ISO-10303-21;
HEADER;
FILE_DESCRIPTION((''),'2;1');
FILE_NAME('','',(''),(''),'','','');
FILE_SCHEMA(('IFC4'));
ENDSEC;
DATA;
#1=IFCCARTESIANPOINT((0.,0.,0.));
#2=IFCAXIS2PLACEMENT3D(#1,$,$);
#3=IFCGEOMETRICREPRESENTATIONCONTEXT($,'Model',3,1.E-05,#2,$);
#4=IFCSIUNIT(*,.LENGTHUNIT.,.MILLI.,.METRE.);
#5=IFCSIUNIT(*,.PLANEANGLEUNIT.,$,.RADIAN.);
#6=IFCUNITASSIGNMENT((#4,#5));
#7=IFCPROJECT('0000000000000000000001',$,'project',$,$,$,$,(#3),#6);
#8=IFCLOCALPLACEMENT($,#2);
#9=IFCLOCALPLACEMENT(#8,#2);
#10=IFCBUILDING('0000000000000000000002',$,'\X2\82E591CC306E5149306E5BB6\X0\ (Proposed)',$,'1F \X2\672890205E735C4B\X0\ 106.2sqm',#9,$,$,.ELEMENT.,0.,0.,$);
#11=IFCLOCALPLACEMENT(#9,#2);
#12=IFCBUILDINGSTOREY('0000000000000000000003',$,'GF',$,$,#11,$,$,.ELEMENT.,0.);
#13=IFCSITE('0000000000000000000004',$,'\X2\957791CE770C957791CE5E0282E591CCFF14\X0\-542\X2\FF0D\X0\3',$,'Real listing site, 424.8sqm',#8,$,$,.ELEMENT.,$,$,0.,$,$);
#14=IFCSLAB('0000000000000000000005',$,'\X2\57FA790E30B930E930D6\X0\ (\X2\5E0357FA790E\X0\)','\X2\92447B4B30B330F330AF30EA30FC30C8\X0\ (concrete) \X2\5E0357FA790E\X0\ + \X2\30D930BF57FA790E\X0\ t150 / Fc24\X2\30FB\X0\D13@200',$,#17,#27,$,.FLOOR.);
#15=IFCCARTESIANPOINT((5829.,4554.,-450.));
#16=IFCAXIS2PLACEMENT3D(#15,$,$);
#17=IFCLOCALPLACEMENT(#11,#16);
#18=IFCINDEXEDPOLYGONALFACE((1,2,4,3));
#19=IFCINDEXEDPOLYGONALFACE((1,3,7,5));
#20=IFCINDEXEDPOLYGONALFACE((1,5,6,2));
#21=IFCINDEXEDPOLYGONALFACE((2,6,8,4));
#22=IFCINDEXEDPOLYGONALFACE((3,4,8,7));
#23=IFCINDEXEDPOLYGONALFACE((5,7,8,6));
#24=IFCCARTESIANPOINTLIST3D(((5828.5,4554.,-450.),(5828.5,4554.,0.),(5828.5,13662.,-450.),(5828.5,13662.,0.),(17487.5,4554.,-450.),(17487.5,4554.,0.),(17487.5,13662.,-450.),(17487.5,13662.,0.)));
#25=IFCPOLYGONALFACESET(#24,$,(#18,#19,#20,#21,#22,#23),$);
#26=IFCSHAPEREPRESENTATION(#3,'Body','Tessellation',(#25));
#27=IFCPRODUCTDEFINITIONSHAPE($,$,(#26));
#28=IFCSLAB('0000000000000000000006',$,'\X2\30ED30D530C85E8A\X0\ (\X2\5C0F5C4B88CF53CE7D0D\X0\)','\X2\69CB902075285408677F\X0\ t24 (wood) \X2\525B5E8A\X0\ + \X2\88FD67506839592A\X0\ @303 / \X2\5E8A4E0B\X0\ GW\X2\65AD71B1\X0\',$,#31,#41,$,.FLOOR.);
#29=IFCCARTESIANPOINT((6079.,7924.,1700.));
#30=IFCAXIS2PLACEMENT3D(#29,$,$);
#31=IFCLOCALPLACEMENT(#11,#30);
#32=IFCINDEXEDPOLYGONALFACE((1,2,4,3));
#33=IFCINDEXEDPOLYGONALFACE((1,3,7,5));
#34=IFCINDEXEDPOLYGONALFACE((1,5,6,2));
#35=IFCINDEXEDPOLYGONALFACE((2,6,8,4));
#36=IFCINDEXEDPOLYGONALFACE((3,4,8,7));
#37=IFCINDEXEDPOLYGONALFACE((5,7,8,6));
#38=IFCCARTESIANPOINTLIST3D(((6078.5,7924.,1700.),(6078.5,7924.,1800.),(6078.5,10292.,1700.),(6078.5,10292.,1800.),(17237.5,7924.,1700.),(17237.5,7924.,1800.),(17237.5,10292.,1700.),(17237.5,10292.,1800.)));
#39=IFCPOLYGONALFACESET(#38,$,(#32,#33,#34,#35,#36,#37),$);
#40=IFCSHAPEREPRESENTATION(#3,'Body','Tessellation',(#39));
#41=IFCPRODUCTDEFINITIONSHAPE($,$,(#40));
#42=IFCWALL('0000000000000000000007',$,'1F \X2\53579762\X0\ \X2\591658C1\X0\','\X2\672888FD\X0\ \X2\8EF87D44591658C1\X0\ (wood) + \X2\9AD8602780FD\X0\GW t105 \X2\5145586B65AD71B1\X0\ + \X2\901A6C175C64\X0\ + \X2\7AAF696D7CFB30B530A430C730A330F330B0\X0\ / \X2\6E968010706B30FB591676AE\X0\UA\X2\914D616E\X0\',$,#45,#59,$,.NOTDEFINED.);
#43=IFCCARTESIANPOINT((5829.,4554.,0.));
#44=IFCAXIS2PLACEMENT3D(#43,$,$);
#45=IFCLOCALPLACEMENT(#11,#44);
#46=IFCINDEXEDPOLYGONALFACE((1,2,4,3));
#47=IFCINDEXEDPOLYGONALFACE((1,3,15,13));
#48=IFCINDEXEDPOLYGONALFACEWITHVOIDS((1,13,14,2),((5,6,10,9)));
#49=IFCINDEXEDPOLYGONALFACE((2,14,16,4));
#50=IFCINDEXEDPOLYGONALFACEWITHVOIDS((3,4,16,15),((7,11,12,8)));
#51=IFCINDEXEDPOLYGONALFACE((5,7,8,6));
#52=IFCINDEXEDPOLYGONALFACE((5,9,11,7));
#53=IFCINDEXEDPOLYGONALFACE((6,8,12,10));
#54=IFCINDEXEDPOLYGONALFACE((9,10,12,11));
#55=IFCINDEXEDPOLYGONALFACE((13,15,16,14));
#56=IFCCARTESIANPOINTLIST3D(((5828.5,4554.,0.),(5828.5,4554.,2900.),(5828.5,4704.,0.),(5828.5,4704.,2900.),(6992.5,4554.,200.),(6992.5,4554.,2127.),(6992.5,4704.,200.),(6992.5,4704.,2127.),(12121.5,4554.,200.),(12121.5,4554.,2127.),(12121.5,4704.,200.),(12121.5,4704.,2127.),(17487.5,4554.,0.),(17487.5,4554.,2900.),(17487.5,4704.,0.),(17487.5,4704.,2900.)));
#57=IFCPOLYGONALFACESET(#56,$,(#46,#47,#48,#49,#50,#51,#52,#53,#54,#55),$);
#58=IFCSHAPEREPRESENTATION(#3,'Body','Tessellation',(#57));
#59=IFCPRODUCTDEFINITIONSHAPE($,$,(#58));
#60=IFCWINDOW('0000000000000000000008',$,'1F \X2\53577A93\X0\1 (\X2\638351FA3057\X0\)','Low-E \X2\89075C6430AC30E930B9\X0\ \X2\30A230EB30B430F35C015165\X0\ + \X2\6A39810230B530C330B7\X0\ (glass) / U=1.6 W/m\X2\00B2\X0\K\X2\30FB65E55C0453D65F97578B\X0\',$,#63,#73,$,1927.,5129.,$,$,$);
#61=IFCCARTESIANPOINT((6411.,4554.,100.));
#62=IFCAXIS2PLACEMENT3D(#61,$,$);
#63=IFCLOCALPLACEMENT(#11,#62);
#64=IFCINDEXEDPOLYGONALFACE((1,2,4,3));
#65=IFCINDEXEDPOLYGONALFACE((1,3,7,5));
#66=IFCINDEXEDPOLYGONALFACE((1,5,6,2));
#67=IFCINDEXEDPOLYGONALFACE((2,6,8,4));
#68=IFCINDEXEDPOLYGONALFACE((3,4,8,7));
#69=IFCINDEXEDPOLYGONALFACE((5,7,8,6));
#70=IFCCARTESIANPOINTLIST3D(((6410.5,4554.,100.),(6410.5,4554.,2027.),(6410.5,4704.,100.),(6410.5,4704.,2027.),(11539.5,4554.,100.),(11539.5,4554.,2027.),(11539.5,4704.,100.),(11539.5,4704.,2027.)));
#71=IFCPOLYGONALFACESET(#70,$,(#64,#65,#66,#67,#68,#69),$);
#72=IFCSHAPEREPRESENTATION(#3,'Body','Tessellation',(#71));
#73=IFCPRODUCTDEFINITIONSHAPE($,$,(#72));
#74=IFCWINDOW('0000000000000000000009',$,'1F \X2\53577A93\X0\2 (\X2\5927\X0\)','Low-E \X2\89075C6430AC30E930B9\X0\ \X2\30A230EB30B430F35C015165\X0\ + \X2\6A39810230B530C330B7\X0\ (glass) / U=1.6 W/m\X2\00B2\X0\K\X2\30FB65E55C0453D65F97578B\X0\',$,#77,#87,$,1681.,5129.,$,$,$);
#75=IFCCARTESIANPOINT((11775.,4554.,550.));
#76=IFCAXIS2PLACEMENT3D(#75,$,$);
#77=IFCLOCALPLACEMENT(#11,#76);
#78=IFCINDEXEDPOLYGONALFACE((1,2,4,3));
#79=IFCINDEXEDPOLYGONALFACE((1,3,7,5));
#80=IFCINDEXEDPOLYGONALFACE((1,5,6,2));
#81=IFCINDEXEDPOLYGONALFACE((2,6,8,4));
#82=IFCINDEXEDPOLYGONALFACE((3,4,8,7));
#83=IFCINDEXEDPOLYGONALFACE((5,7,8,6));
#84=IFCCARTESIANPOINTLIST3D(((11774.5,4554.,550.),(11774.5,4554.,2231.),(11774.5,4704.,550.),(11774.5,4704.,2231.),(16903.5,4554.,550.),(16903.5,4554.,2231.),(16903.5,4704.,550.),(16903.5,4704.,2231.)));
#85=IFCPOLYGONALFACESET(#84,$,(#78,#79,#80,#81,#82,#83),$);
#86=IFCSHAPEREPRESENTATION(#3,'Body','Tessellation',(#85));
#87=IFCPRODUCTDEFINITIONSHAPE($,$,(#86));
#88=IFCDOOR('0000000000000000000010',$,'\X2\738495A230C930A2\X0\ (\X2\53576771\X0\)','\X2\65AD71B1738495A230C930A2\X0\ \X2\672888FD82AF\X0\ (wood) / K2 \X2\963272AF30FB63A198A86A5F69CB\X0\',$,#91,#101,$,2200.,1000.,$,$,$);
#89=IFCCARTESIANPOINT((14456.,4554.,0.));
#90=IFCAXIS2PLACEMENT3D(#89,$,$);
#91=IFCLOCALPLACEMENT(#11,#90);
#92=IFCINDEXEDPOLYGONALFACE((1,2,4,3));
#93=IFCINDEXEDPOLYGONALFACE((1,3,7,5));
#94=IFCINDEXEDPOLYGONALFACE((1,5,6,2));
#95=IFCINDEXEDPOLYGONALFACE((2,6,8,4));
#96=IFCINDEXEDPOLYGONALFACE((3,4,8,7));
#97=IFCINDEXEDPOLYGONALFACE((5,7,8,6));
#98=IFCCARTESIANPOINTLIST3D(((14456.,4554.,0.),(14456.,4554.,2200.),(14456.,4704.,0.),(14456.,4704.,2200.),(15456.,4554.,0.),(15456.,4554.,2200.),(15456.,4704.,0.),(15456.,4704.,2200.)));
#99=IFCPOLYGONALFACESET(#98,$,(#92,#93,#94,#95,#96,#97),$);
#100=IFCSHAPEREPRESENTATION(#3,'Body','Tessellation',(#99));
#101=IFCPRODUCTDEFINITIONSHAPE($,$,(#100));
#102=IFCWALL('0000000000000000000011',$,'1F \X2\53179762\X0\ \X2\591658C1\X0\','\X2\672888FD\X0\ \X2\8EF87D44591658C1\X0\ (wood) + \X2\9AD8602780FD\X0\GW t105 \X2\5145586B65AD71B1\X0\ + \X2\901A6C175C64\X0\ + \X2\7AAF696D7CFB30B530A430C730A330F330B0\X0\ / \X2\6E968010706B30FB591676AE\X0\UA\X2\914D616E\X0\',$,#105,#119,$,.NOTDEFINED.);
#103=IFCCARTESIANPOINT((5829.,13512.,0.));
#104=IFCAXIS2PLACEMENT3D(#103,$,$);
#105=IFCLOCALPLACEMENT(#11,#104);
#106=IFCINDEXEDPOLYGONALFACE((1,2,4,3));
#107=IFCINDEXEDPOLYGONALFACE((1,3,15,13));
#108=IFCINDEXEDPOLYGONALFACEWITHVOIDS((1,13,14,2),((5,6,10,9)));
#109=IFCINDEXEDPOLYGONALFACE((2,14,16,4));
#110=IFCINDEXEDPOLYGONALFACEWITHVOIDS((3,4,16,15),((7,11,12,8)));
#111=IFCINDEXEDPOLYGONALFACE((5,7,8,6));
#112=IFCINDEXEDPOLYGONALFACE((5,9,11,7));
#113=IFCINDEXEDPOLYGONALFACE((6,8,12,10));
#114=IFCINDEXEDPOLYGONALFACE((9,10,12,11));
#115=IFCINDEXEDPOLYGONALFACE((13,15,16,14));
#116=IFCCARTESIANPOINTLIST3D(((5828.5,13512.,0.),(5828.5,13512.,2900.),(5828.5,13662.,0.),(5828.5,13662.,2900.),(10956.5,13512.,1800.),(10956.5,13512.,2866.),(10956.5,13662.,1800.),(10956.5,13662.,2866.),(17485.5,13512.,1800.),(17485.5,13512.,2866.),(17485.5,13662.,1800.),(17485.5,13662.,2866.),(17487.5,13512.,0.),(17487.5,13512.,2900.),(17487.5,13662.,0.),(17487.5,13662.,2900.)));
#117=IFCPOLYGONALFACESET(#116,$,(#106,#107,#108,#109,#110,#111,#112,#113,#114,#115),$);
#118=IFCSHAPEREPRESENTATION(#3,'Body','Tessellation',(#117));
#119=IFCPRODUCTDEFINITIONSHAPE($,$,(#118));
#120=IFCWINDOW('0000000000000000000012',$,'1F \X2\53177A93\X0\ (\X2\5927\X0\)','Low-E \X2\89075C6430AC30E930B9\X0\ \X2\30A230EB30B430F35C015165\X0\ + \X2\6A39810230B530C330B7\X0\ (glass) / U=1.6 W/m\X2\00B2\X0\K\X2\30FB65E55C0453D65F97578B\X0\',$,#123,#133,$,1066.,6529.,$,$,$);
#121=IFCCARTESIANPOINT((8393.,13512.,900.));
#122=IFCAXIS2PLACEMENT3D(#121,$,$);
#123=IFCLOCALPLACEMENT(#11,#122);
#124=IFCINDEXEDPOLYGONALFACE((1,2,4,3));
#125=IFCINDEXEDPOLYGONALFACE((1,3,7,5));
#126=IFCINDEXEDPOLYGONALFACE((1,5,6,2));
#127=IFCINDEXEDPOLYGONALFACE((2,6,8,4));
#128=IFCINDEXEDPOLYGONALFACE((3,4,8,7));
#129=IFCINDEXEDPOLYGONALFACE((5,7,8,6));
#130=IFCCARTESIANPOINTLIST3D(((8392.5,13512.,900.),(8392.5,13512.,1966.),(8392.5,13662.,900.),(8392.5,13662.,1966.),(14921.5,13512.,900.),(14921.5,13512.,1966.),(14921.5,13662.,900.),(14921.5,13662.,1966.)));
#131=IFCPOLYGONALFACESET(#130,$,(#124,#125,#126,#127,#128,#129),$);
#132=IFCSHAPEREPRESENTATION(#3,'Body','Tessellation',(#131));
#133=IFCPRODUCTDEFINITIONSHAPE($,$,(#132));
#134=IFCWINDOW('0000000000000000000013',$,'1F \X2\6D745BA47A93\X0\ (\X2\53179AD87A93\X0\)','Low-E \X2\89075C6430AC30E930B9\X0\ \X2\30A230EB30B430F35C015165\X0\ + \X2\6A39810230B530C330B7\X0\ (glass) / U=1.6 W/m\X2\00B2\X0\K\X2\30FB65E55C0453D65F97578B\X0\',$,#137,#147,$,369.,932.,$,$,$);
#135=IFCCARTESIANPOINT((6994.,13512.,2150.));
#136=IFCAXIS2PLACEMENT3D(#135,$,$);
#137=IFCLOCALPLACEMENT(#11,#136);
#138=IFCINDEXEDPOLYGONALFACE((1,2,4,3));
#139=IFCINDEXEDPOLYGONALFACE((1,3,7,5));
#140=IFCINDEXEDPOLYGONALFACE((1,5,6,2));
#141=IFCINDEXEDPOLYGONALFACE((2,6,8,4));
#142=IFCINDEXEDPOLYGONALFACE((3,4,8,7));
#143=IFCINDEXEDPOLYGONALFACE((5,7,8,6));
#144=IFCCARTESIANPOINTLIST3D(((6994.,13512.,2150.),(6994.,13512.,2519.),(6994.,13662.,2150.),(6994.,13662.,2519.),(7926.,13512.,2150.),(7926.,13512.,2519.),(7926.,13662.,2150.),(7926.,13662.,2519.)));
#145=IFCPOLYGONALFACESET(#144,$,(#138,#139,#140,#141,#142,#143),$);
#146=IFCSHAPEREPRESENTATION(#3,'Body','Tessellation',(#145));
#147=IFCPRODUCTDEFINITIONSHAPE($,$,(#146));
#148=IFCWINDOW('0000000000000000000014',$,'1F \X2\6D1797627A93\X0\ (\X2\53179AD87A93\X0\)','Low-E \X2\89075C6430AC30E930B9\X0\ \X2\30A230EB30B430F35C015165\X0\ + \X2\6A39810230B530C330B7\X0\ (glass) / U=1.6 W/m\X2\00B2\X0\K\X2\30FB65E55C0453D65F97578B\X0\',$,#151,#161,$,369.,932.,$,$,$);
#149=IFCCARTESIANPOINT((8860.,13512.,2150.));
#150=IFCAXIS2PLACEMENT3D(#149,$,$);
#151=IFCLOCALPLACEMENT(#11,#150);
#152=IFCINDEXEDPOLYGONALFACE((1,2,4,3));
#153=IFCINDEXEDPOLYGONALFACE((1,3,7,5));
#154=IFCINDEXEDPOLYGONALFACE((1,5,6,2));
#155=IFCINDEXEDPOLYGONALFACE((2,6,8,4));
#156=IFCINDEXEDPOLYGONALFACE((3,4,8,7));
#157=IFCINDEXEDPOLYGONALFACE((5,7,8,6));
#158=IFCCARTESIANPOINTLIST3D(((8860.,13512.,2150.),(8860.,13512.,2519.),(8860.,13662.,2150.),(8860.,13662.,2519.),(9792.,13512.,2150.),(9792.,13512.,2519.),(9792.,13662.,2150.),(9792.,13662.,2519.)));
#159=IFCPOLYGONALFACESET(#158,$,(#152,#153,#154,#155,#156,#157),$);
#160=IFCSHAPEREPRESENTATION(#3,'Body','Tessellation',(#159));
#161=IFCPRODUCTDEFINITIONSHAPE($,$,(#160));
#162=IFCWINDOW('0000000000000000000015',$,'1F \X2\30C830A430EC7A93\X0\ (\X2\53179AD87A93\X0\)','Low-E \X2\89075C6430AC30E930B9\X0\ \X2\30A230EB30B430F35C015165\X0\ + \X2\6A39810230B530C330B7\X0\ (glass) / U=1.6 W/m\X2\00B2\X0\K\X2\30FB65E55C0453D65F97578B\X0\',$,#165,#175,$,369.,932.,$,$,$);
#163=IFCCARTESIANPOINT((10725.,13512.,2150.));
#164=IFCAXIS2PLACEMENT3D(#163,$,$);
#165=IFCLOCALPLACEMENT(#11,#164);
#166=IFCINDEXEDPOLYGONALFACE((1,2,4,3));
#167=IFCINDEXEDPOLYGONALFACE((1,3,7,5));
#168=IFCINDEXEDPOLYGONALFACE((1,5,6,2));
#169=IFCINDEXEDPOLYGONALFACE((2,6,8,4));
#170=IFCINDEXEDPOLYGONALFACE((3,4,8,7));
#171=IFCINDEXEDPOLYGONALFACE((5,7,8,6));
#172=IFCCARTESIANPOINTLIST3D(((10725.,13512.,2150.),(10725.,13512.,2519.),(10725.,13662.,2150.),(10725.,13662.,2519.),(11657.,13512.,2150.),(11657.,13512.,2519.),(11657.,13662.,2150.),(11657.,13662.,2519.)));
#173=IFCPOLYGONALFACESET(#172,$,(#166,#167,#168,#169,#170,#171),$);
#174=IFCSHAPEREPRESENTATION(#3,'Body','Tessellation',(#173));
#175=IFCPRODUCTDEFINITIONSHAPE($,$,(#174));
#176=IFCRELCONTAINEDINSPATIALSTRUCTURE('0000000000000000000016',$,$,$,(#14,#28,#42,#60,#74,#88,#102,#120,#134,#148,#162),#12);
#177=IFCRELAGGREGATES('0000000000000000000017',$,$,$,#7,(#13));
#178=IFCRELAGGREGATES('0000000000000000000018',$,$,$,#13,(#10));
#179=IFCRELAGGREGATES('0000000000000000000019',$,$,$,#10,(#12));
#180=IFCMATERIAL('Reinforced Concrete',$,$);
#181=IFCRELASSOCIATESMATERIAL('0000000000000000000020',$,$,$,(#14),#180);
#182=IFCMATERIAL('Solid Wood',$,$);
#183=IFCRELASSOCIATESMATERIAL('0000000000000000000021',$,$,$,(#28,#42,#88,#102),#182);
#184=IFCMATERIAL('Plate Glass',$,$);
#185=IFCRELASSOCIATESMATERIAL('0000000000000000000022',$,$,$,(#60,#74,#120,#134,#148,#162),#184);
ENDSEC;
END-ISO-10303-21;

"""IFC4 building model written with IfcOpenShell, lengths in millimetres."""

from ifc_helpers import new_model, si_unit, frame, frame_2d, origin, place, context, project, spatial, rectangle, extrude, material, element, fill, save


model = new_model("IFC4")

# Units and contexts
model_context = context("Model", 3, precision=1e-05, world=origin())
ifc_project = project(units=[si_unit("LENGTHUNIT", "METRE", prefix="MILLI"), si_unit("PLANEANGLEUNIT", "RADIAN")], contexts=[model_context])

# Site, building, storey
site_placement = place(None, origin())
site = spatial("IfcSite", under=ifc_project, at=site_placement, Name="長野県長野市若里４-542－3", ObjectType="Real listing site, 424.8sqm", CompositionType="ELEMENT", RefElevation=0.0)
building_placement = place(site_placement, origin())
building = spatial("IfcBuilding", under=site, at=building_placement, Name="若里の光の家 (Proposed)", ObjectType="1F 木造平屋 106.2sqm", CompositionType="ELEMENT", ElevationOfRefHeight=0.0, ElevationOfTerrain=0.0)
storey_placement = place(building_placement, origin())
storey = spatial("IfcBuildingStorey", under=building, at=storey_placement, Name="GF", CompositionType="ELEMENT", Elevation=0.0)

# Slabs
ifc_material_1 = material(Name="Reinforced Concrete")
slab_1_placement = place(storey_placement, frame((5829.0, 4554.0, -450.0)))
element("IfcSlab", 1, at=slab_1_placement, inside=storey, material=ifc_material_1, Name="基礎スラブ (布基礎)", Description="鉄筋コンクリート (concrete) 布基礎 + ベタ基礎 t150 / Fc24・D13@200", PredefinedType="FLOOR", context=model_context, shape_type="SweptSolid", body=[
    extrude(rectangle(XDim=11659.0, YDim=9108.0, at=frame_2d((5829.0, 4554.0))), frame((5829.0, 4554.0, -450.0)), (0.0, 0.0, 1.0), 450.0),
])
ifc_material_2 = material(Name="Solid Wood")
slab_2_placement = place(storey_placement, frame((6079.0, 7924.0, 1700.0)))
element("IfcSlab", 2, at=slab_2_placement, inside=storey, material=ifc_material_2, Name="ロフト床 (小屋裏収納)", Description="構造用合板 t24 (wood) 剛床 + 製材根太 @303 / 床下 GW断熱", PredefinedType="FLOOR", context=model_context, shape_type="SweptSolid", body=[
    extrude(rectangle(XDim=11159.0, YDim=2368.0, at=frame_2d((5579.0, 1184.0))), frame((6079.0, 7924.0, 1700.0)), (0.0, 0.0, 1.0), 100.0),
])

# Wall, openings, windows, door
wall_1_placement = place(storey_placement, frame((5829.0, 4554.0, 0.0)))
wall_1 = element("IfcWall", 3, at=wall_1_placement, inside=storey, material=ifc_material_2, Name="1F 南面 外壁", Description="木製 軸組外壁 (wood) + 高性能GW t105 充填断熱 + 通気層 + 窯業系サイディング / 準耐火・外皮UA配慮", PredefinedType="NOTDEFINED", context=model_context, shape_type="SweptSolid", body=[
    extrude(rectangle(XDim=11659.0, YDim=150.0, at=frame_2d((5829.0, 75.0))), frame((5829.0, 4554.0, 0.0)), (0.0, 0.0, 1.0), 2900.0),
])
opening_1_placement = place(storey_placement, frame((6411.0, 4554.0, 100.0)))
opening_1 = element("IfcOpeningElement", 4, at=opening_1_placement, cuts=wall_1, PredefinedType="NOTDEFINED", context=model_context, shape_type="SweptSolid", body=[
    extrude(rectangle(XDim=5129.0, YDim=150.0, at=frame_2d((2564.0, 75.0))), frame((6411.0, 4554.0, 100.0)), (0.0, 0.0, 1.0), 1927.0),
])
opening_2_placement = place(storey_placement, frame((11775.0, 4554.0, 550.0)))
opening_2 = element("IfcOpeningElement", 5, at=opening_2_placement, cuts=wall_1, PredefinedType="NOTDEFINED", context=model_context, shape_type="SweptSolid", body=[
    extrude(rectangle(XDim=5129.0, YDim=150.0, at=frame_2d((2564.0, 75.0))), frame((11775.0, 4554.0, 550.0)), (0.0, 0.0, 1.0), 1681.0),
])
opening_3_placement = place(storey_placement, frame((14456.0, 4554.0, 0.0)))
opening_3 = element("IfcOpeningElement", 6, at=opening_3_placement, cuts=wall_1, PredefinedType="NOTDEFINED", context=model_context, shape_type="SweptSolid", body=[
    extrude(rectangle(XDim=1000.0, YDim=150.0, at=frame_2d((500.0, 75.0))), frame((14456.0, 4554.0, 0.0)), (0.0, 0.0, 1.0), 2200.0),
])
ifc_material_3 = material(Name="Plate Glass")
window_1_placement = place(storey_placement, frame((6411.0, 4554.0, 100.0)))
window_1 = element("IfcWindow", 7, at=window_1_placement, inside=storey, material=ifc_material_3, Name="1F 南窓1 (掃出し)", Description="Low-E 複層ガラス アルゴン封入 + 樹脂サッシ (glass) / U=1.6 W/m²K・日射取得型", OverallHeight=1927.0, OverallWidth=5129.0, context=model_context, shape_type="SweptSolid", body=[
    extrude(rectangle(XDim=5129.0, YDim=150.0, at=frame_2d((2564.0, 75.0))), frame((6411.0, 4554.0, 100.0)), (0.0, 0.0, 1.0), 1927.0),
])
fill(opening_1, window_1)
window_2_placement = place(storey_placement, frame((11775.0, 4554.0, 550.0)))
window_2 = element("IfcWindow", 8, at=window_2_placement, inside=storey, material=ifc_material_3, Name="1F 南窓2 (大)", Description="Low-E 複層ガラス アルゴン封入 + 樹脂サッシ (glass) / U=1.6 W/m²K・日射取得型", OverallHeight=1681.0, OverallWidth=5129.0, context=model_context, shape_type="SweptSolid", body=[
    extrude(rectangle(XDim=5129.0, YDim=150.0, at=frame_2d((2564.0, 75.0))), frame((11775.0, 4554.0, 550.0)), (0.0, 0.0, 1.0), 1681.0),
])
fill(opening_2, window_2)
door_1_placement = place(storey_placement, frame((14456.0, 4554.0, 0.0)))
door_1 = element("IfcDoor", 9, at=door_1_placement, inside=storey, material=ifc_material_2, Name="玄関ドア (南東)", Description="断熱玄関ドア 木製芯 (wood) / K2 防犯・採風機構", OverallHeight=2200.0, OverallWidth=1000.0, context=model_context, shape_type="SweptSolid", body=[
    extrude(rectangle(XDim=1000.0, YDim=150.0, at=frame_2d((500.0, 75.0))), frame((14456.0, 4554.0, 0.0)), (0.0, 0.0, 1.0), 2200.0),
])
fill(opening_3, door_1)

# Wall, openings, windows
wall_2_placement = place(storey_placement, frame((5829.0, 13512.0, 0.0)))
wall_2 = element("IfcWall", 10, at=wall_2_placement, inside=storey, material=ifc_material_2, Name="1F 北面 外壁", Description="木製 軸組外壁 (wood) + 高性能GW t105 充填断熱 + 通気層 + 窯業系サイディング / 準耐火・外皮UA配慮", PredefinedType="NOTDEFINED", context=model_context, shape_type="SweptSolid", body=[
    extrude(rectangle(XDim=11659.0, YDim=150.0, at=frame_2d((5829.0, 75.0))), frame((5829.0, 13512.0, 0.0)), (0.0, 0.0, 1.0), 2900.0),
])
opening_4_placement = place(storey_placement, frame((8393.0, 13512.0, 900.0)))
opening_4 = element("IfcOpeningElement", 11, at=opening_4_placement, cuts=wall_2, PredefinedType="NOTDEFINED", context=model_context, shape_type="SweptSolid", body=[
    extrude(rectangle(XDim=6529.0, YDim=150.0, at=frame_2d((3264.0, 75.0))), frame((8393.0, 13512.0, 900.0)), (0.0, 0.0, 1.0), 1066.0),
])
opening_5_placement = place(storey_placement, frame((6994.0, 13512.0, 2150.0)))
opening_5 = element("IfcOpeningElement", 12, at=opening_5_placement, cuts=wall_2, PredefinedType="NOTDEFINED", context=model_context, shape_type="SweptSolid", body=[
    extrude(rectangle(XDim=932.0, YDim=150.0, at=frame_2d((466.0, 75.0))), frame((6994.0, 13512.0, 2150.0)), (0.0, 0.0, 1.0), 369.0),
])
opening_6_placement = place(storey_placement, frame((8860.0, 13512.0, 2150.0)))
opening_6 = element("IfcOpeningElement", 13, at=opening_6_placement, cuts=wall_2, PredefinedType="NOTDEFINED", context=model_context, shape_type="SweptSolid", body=[
    extrude(rectangle(XDim=932.0, YDim=150.0, at=frame_2d((466.0, 75.0))), frame((8860.0, 13512.0, 2150.0)), (0.0, 0.0, 1.0), 369.0),
])
opening_7_placement = place(storey_placement, frame((10725.0, 13512.0, 2150.0)))
opening_7 = element("IfcOpeningElement", 14, at=opening_7_placement, cuts=wall_2, PredefinedType="NOTDEFINED", context=model_context, shape_type="SweptSolid", body=[
    extrude(rectangle(XDim=932.0, YDim=150.0, at=frame_2d((466.0, 75.0))), frame((10725.0, 13512.0, 2150.0)), (0.0, 0.0, 1.0), 369.0),
])
window_3_placement = place(storey_placement, frame((8393.0, 13512.0, 900.0)))
window_3 = element("IfcWindow", 15, at=window_3_placement, inside=storey, material=ifc_material_3, Name="1F 北窓 (大)", Description="Low-E 複層ガラス アルゴン封入 + 樹脂サッシ (glass) / U=1.6 W/m²K・日射取得型", OverallHeight=1066.0, OverallWidth=6529.0, context=model_context, shape_type="SweptSolid", body=[
    extrude(rectangle(XDim=6529.0, YDim=150.0, at=frame_2d((3264.0, 75.0))), frame((8393.0, 13512.0, 900.0)), (0.0, 0.0, 1.0), 1066.0),
])
fill(opening_4, window_3)
window_4_placement = place(storey_placement, frame((6994.0, 13512.0, 2150.0)))
window_4 = element("IfcWindow", 16, at=window_4_placement, inside=storey, material=ifc_material_3, Name="1F 浴室窓 (北高窓)", Description="Low-E 複層ガラス アルゴン封入 + 樹脂サッシ (glass) / U=1.6 W/m²K・日射取得型", OverallHeight=369.0, OverallWidth=932.0, context=model_context, shape_type="SweptSolid", body=[
    extrude(rectangle(XDim=932.0, YDim=150.0, at=frame_2d((466.0, 75.0))), frame((6994.0, 13512.0, 2150.0)), (0.0, 0.0, 1.0), 369.0),
])
fill(opening_5, window_4)
window_5_placement = place(storey_placement, frame((8860.0, 13512.0, 2150.0)))
window_5 = element("IfcWindow", 17, at=window_5_placement, inside=storey, material=ifc_material_3, Name="1F 洗面窓 (北高窓)", Description="Low-E 複層ガラス アルゴン封入 + 樹脂サッシ (glass) / U=1.6 W/m²K・日射取得型", OverallHeight=369.0, OverallWidth=932.0, context=model_context, shape_type="SweptSolid", body=[
    extrude(rectangle(XDim=932.0, YDim=150.0, at=frame_2d((466.0, 75.0))), frame((8860.0, 13512.0, 2150.0)), (0.0, 0.0, 1.0), 369.0),
])
fill(opening_6, window_5)
window_6_placement = place(storey_placement, frame((10725.0, 13512.0, 2150.0)))
window_6 = element("IfcWindow", 18, at=window_6_placement, inside=storey, material=ifc_material_3, Name="1F トイレ窓 (北高窓)", Description="Low-E 複層ガラス アルゴン封入 + 樹脂サッシ (glass) / U=1.6 W/m²K・日射取得型", OverallHeight=369.0, OverallWidth=932.0, context=model_context, shape_type="SweptSolid", body=[
    extrude(rectangle(XDim=932.0, YDim=150.0, at=frame_2d((466.0, 75.0))), frame((10725.0, 13512.0, 2150.0)), (0.0, 0.0, 1.0), 369.0),
])
fill(opening_7, window_6)

save(model, "model.ifc")
